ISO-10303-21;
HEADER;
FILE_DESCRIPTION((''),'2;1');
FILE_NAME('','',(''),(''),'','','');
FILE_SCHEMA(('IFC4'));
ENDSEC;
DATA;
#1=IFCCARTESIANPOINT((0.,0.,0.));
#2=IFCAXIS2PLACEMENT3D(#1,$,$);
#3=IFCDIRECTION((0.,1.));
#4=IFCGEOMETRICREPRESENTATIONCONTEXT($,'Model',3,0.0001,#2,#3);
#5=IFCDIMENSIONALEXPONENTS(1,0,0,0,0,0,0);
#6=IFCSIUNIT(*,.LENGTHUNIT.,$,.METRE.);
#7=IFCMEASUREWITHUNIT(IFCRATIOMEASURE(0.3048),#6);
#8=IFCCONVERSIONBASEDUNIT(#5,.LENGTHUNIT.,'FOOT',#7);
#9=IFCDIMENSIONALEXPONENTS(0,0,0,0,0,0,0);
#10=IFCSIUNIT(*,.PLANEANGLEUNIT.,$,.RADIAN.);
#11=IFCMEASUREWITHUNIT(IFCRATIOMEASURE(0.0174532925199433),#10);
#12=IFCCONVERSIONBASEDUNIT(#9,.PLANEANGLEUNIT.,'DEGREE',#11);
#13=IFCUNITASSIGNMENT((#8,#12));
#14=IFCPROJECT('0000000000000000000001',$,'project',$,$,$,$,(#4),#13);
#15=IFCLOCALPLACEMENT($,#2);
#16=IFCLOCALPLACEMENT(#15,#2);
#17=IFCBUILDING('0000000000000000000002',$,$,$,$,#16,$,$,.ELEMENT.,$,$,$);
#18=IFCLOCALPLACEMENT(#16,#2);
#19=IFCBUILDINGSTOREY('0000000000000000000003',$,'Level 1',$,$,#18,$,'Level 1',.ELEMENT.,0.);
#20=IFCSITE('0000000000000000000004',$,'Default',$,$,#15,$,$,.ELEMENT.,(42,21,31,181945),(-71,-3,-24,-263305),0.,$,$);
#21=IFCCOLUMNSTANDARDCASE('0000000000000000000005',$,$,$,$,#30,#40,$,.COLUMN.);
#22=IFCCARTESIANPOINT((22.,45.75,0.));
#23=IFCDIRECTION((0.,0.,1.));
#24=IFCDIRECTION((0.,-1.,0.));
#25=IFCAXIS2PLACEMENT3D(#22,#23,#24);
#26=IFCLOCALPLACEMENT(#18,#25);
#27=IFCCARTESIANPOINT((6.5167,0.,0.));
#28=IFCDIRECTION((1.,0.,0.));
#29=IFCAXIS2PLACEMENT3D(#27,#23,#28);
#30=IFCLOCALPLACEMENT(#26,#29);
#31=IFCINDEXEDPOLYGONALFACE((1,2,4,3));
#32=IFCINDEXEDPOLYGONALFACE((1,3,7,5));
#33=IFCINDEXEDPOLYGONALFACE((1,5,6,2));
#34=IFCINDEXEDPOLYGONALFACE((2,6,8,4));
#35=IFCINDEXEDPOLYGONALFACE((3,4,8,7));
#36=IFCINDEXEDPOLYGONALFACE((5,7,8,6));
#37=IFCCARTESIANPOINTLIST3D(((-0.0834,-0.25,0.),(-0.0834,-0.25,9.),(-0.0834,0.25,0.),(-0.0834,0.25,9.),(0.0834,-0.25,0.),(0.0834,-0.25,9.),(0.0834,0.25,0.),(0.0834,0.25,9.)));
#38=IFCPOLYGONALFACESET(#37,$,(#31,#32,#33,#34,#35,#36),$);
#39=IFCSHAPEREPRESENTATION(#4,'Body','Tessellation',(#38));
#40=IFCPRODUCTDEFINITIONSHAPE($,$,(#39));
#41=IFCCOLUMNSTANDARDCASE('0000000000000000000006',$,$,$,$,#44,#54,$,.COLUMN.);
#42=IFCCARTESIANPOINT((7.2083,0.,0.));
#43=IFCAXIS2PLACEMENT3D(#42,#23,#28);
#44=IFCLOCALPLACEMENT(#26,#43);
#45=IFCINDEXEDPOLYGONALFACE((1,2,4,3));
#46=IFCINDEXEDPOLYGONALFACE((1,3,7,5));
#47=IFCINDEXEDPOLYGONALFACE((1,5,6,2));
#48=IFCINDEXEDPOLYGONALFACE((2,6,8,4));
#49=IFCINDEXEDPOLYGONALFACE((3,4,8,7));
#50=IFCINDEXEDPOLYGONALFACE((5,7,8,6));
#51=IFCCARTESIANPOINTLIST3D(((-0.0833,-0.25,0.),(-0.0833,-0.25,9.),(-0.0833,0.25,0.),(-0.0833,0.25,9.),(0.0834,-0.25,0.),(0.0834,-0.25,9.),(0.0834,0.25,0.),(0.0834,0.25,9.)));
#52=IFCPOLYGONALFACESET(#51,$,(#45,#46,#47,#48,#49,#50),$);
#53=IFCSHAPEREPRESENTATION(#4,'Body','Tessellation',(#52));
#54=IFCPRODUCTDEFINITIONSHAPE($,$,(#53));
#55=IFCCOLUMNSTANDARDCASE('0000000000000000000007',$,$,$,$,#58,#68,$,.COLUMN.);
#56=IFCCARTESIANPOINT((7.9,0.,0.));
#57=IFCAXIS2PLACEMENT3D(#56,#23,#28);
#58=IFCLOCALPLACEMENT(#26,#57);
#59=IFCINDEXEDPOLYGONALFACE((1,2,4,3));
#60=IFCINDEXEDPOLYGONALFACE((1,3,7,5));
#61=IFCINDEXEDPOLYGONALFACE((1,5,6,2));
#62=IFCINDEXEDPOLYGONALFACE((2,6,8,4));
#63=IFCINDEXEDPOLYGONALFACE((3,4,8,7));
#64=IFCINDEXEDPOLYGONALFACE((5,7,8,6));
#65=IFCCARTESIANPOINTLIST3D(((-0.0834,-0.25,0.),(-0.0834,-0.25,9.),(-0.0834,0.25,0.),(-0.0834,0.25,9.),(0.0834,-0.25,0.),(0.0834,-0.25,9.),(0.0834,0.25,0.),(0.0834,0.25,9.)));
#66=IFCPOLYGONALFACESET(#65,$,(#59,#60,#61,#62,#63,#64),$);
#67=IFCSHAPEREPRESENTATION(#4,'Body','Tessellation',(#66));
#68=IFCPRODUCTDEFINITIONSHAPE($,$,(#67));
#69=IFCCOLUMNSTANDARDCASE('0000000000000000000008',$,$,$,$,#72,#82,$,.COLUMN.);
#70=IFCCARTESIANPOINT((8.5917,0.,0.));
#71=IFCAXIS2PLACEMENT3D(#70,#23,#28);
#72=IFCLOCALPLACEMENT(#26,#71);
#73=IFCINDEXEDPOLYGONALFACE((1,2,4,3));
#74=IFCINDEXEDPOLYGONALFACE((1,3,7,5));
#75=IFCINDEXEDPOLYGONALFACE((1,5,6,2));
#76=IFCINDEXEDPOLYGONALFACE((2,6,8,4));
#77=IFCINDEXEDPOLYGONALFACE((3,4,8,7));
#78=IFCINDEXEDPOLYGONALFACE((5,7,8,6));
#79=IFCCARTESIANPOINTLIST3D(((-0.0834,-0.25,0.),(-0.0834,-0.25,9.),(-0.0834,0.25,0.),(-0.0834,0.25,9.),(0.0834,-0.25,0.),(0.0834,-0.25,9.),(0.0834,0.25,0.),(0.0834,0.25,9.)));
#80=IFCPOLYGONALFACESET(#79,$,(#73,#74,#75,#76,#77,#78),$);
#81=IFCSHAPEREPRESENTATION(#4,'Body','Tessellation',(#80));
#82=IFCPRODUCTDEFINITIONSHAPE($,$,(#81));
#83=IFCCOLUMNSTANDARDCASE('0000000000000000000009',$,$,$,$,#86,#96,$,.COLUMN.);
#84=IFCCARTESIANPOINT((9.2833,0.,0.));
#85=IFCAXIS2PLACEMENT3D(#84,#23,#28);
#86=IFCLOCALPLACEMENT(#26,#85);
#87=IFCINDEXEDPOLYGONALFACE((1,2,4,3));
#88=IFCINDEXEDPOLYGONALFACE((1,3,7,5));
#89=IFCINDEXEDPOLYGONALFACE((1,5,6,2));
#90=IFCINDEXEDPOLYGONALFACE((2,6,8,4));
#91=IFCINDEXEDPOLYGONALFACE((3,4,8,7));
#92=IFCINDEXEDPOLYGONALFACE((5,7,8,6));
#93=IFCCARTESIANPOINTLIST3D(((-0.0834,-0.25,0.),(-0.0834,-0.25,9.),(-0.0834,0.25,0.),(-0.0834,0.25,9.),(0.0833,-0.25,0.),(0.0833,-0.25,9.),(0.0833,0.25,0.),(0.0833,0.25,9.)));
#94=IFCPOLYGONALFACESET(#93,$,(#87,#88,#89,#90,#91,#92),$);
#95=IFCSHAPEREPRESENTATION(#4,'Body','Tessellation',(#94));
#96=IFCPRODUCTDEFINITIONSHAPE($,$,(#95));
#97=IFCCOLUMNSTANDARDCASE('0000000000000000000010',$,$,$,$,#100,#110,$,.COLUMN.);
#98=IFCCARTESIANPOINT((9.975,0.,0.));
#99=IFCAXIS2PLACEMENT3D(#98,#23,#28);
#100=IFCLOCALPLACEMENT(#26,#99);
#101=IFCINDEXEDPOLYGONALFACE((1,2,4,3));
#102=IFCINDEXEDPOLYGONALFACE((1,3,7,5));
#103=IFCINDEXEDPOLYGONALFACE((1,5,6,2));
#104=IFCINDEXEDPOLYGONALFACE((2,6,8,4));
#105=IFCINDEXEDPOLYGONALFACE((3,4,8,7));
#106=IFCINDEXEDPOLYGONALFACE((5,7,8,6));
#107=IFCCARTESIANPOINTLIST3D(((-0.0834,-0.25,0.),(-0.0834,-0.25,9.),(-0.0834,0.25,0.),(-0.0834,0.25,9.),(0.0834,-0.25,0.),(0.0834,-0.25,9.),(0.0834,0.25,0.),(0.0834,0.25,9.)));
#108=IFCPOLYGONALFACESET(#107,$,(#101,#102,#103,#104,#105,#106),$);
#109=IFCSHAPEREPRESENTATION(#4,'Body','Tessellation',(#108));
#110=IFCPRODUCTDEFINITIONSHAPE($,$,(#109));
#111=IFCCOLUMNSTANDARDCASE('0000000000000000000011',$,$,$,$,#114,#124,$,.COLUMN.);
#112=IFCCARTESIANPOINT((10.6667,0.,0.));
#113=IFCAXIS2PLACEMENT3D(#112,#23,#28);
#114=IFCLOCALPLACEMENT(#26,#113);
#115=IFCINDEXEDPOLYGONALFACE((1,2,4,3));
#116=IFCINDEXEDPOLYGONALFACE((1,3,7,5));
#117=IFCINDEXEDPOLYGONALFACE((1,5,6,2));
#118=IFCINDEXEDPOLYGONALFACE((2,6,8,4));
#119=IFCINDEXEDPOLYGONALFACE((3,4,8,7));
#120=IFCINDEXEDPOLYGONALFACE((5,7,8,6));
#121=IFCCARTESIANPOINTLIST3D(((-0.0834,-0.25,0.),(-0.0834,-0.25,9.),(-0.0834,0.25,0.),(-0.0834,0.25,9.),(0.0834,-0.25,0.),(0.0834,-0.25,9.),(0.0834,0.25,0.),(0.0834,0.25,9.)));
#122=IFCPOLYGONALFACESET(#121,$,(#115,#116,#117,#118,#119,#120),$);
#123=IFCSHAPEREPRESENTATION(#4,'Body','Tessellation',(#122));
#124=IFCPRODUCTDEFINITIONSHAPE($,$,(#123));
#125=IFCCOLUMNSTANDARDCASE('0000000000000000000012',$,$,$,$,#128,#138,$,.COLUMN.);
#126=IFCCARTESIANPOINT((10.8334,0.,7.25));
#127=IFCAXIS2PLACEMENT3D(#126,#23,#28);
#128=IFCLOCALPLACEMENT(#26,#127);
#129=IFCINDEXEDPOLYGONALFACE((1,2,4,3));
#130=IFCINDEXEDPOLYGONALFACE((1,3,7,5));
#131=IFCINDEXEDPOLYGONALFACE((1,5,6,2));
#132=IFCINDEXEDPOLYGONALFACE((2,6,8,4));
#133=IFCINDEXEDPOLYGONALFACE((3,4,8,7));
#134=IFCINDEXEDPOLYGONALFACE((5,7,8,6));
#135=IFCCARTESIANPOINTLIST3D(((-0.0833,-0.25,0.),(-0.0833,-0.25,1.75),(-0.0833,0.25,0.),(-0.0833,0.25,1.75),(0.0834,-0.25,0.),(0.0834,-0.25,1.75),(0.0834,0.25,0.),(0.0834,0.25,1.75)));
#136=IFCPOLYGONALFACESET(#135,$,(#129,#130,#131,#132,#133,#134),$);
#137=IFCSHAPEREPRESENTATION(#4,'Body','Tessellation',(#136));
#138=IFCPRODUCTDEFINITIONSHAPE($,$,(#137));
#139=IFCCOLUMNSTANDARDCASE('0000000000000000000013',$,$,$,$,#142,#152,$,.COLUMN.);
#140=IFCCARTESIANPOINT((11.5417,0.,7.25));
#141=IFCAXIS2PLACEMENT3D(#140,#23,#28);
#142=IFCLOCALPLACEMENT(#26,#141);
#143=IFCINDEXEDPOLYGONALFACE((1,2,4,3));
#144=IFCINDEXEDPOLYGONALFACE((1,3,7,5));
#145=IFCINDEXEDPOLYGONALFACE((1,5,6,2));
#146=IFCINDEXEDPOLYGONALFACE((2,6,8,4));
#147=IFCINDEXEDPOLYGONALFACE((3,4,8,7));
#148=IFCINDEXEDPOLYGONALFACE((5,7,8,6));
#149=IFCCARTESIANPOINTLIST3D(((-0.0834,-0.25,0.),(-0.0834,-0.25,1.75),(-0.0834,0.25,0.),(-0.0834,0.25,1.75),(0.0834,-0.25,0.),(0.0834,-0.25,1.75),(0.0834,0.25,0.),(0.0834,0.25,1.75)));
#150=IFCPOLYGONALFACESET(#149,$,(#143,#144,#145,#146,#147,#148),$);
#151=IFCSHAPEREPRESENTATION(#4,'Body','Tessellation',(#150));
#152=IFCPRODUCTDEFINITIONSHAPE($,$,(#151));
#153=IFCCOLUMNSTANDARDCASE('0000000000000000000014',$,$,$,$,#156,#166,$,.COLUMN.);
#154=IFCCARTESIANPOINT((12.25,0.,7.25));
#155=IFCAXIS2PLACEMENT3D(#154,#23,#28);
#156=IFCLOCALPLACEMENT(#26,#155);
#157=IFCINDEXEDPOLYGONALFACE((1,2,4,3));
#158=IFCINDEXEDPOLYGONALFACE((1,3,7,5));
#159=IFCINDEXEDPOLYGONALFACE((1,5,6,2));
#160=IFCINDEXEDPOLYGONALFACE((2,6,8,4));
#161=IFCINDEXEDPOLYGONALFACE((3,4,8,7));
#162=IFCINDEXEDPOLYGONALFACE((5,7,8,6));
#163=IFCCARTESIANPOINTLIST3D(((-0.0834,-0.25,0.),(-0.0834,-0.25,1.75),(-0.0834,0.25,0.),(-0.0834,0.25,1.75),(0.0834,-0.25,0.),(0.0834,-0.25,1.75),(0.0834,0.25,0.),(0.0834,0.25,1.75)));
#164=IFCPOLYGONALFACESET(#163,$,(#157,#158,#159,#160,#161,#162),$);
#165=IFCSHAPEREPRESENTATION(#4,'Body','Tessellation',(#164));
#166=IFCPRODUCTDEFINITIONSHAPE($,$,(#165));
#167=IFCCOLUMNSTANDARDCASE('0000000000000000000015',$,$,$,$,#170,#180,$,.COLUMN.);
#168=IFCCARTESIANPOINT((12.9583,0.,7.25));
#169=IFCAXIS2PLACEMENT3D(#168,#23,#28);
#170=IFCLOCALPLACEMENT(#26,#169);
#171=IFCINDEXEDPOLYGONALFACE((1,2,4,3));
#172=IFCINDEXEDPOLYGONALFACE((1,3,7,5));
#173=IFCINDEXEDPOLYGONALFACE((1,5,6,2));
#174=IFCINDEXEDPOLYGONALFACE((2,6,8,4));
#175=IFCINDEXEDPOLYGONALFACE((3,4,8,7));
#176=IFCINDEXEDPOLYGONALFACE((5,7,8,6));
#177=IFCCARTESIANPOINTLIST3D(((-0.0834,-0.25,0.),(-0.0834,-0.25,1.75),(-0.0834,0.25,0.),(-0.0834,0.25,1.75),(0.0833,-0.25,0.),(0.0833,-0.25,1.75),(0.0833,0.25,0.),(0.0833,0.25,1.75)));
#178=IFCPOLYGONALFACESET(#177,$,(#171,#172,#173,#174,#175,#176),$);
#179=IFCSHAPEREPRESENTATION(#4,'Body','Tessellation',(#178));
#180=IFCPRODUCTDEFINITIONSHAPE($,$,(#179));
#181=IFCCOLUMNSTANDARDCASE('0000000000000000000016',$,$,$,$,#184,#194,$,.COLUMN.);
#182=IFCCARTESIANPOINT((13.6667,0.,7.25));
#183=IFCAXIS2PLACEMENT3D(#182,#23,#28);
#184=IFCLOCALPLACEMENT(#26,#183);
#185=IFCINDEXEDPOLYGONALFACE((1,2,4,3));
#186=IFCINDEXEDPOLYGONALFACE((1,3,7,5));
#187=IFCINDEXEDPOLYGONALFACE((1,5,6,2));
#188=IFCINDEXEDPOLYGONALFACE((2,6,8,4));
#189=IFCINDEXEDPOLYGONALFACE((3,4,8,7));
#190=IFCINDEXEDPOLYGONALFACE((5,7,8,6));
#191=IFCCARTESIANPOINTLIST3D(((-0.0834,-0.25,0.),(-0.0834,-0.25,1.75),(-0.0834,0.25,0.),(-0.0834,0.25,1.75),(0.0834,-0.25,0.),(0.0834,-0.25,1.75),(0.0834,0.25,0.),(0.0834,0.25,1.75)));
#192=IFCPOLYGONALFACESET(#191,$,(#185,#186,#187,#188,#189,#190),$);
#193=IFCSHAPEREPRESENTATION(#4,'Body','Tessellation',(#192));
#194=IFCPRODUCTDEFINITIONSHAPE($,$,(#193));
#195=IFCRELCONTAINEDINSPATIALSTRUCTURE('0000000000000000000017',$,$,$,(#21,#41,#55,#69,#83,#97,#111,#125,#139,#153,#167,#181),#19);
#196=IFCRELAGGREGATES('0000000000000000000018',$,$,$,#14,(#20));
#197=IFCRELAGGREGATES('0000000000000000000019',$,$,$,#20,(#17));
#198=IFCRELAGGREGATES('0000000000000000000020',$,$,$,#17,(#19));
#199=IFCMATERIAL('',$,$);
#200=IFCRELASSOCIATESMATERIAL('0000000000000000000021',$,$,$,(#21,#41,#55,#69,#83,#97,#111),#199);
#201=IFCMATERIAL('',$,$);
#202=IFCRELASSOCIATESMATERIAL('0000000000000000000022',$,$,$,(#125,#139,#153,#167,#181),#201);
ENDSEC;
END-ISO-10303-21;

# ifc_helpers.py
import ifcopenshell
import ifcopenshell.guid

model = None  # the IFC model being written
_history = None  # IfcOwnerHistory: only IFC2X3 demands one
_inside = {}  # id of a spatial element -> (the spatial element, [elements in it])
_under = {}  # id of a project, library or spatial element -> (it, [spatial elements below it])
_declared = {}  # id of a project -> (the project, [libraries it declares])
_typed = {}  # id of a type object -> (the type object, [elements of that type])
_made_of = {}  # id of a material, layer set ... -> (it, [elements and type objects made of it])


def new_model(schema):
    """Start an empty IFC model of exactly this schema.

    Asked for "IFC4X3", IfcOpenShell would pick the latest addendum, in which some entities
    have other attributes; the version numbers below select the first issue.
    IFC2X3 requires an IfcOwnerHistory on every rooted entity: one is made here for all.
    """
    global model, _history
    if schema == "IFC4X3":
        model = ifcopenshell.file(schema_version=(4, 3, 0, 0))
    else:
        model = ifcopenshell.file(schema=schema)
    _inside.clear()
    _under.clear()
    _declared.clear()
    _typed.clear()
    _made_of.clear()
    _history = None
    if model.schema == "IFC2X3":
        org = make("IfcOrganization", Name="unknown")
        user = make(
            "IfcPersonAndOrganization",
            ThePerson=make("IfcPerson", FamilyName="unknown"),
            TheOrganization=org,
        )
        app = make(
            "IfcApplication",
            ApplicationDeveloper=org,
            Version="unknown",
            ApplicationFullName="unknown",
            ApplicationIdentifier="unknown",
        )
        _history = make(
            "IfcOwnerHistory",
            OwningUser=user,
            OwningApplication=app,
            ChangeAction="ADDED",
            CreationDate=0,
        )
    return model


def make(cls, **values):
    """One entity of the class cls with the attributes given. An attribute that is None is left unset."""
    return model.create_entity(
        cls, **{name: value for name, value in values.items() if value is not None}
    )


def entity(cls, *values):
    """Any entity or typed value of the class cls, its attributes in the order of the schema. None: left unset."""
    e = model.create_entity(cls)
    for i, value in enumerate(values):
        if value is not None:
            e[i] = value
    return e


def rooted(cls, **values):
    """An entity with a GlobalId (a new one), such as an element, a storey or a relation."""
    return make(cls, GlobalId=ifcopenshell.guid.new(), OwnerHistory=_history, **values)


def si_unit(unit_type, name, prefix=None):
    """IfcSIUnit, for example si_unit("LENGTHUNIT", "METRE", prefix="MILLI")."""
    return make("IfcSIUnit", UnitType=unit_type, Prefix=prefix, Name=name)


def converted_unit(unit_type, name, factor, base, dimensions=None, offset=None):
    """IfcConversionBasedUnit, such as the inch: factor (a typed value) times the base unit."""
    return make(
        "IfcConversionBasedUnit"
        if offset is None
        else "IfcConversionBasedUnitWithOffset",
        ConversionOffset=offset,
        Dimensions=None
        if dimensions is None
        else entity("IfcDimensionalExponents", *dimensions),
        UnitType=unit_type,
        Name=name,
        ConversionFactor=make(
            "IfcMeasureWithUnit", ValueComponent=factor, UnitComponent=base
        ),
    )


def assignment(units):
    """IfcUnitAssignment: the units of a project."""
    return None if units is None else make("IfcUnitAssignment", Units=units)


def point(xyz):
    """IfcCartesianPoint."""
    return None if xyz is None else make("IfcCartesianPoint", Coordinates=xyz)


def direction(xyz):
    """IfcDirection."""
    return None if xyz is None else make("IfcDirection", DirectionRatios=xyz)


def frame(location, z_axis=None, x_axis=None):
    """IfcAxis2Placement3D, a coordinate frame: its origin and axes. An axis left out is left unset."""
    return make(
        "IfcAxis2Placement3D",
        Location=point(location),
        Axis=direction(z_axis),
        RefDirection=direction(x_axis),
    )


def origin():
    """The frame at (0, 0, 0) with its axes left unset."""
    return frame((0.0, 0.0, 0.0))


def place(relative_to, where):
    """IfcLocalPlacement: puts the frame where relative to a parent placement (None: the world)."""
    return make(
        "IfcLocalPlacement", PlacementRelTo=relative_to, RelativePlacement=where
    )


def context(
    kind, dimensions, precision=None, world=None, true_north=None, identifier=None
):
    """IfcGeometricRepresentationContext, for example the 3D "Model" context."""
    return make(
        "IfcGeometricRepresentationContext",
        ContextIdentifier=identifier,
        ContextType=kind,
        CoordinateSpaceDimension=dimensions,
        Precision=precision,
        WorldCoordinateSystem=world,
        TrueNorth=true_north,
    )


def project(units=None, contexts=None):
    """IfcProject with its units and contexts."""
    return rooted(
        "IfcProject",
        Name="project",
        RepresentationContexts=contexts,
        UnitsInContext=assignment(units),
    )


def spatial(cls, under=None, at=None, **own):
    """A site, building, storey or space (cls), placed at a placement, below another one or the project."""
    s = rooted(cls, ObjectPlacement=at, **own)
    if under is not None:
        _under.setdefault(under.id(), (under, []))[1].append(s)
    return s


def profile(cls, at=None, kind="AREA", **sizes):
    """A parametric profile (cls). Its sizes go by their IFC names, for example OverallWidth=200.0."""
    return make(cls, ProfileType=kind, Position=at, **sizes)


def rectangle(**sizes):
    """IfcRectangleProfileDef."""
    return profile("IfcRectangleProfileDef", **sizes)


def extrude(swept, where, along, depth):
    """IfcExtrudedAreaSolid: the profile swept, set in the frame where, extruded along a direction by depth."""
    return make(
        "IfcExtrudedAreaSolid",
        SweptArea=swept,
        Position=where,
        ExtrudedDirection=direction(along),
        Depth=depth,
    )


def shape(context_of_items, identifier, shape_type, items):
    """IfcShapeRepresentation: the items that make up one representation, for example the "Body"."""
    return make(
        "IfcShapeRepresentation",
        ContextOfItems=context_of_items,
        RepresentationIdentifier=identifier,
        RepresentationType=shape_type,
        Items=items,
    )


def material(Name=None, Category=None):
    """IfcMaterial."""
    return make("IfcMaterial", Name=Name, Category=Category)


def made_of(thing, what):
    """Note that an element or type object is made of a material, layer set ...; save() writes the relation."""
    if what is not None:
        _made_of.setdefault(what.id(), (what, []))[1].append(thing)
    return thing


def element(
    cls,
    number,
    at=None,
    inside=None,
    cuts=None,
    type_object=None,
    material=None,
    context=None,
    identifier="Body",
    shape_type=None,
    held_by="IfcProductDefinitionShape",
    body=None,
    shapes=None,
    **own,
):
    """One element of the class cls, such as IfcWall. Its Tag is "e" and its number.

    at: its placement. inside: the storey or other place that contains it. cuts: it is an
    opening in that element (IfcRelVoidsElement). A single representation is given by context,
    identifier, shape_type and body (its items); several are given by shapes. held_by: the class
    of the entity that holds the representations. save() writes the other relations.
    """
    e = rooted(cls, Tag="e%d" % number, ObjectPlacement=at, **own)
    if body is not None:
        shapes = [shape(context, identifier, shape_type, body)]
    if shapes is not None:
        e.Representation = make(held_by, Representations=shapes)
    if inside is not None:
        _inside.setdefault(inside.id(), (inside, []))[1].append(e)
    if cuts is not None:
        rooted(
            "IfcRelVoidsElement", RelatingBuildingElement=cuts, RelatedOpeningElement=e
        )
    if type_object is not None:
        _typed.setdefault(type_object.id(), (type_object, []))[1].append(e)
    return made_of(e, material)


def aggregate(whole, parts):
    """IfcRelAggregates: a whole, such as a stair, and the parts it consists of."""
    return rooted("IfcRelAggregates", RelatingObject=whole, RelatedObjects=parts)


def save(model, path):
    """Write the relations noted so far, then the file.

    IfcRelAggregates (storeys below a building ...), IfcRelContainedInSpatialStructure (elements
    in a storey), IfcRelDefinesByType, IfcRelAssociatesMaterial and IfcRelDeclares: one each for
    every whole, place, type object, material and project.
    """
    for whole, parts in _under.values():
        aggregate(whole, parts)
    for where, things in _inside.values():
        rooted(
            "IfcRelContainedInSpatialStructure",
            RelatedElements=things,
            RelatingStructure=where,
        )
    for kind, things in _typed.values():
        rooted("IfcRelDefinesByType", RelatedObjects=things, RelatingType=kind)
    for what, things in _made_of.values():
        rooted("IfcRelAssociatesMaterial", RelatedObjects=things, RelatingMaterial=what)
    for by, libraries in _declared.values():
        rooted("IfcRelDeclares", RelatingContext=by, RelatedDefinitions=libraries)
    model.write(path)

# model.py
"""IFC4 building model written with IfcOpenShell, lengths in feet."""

from ifc_helpers import new_model, entity, si_unit, converted_unit, direction, frame, origin, place, context, project, spatial, rectangle, extrude, material, element, save


model = new_model("IFC4")

# Units and contexts
model_context = context("Model", 3, precision=0.0001, world=origin(), true_north=direction((0.0, 1.0)))
ifc_project = project(units=[converted_unit("LENGTHUNIT", "FOOT", entity("IfcRatioMeasure", 0.3048), si_unit("LENGTHUNIT", "METRE"), dimensions=[1, 0, 0, 0, 0, 0, 0]), converted_unit("PLANEANGLEUNIT", "DEGREE", entity("IfcRatioMeasure", 0.0174532925199433), si_unit("PLANEANGLEUNIT", "RADIAN"), dimensions=[0, 0, 0, 0, 0, 0, 0])], contexts=[model_context])

# Site, building, storey
site_placement = place(None, origin())
site = spatial("IfcSite", under=ifc_project, at=site_placement, Name="Default", CompositionType="ELEMENT", RefLatitude=(42, 21, 31, 181945), RefLongitude=(-71, -3, -24, -263305), RefElevation=0.0)
building_placement = place(site_placement, origin())
building = spatial("IfcBuilding", under=site, at=building_placement, CompositionType="ELEMENT")
storey_placement = place(building_placement, origin())
storey = spatial("IfcBuildingStorey", under=building, at=storey_placement, Name="Level 1", LongName="Level 1", CompositionType="ELEMENT", Elevation=0.0)

# Columns
placement_1 = place(storey_placement, frame((22.0, 45.75, 0.0), z_axis=(0.0, 0.0, 1.0), x_axis=(0.0, -1.0, 0.0)))
ifc_material_1 = material(Name="")
for number, where, z_axis, x_axis in (
    (1, (6.5167, 0.0, 0.0), (0.0, 0.0, 1.0), (1.0, 0.0, 0.0)),
    (2, (7.2083, 0.0, 0.0), (0.0, 0.0, 1.0), (1.0, 0.0, 0.0)),
    (3, (7.9, 0.0, 0.0), (0.0, 0.0, 1.0), (1.0, 0.0, 0.0)),
    (4, (8.5917, 0.0, 0.0), (0.0, 0.0, 1.0), (1.0, 0.0, 0.0)),
    (5, (9.2833, 0.0, 0.0), (0.0, 0.0, 1.0), (1.0, 0.0, 0.0)),
    (6, (9.975, 0.0, 0.0), (0.0, 0.0, 1.0), (1.0, 0.0, 0.0)),
    (7, (10.6667, 0.0, 0.0), (0.0, 0.0, 1.0), (1.0, 0.0, 0.0)),
):
    element("IfcColumnStandardCase", number, at=place(placement_1, frame(where, z_axis=z_axis, x_axis=x_axis)), inside=storey, material=ifc_material_1, PredefinedType="COLUMN", context=model_context, shape_type="SweptSolid", body=[
        extrude(rectangle(XDim=0.1667, YDim=0.5), origin(), (0.0, 0.0, 1.0), 9.0),
    ])
ifc_material_2 = material(Name="")
for number, where, z_axis, x_axis in (
    (8, (10.8334, 0.0, 7.25), (0.0, 0.0, 1.0), (1.0, 0.0, 0.0)),
    (9, (11.5417, 0.0, 7.25), (0.0, 0.0, 1.0), (1.0, 0.0, 0.0)),
    (10, (12.25, 0.0, 7.25), (0.0, 0.0, 1.0), (1.0, 0.0, 0.0)),
    (11, (12.9583, 0.0, 7.25), (0.0, 0.0, 1.0), (1.0, 0.0, 0.0)),
    (12, (13.6667, 0.0, 7.25), (0.0, 0.0, 1.0), (1.0, 0.0, 0.0)),
):
    element("IfcColumnStandardCase", number, at=place(placement_1, frame(where, z_axis=z_axis, x_axis=x_axis)), inside=storey, material=ifc_material_2, PredefinedType="COLUMN", context=model_context, shape_type="SweptSolid", body=[
        extrude(rectangle(XDim=0.1667, YDim=0.5), origin(), (0.0, 0.0, 1.0), 1.75),
    ])

save(model, "model.ifc")
